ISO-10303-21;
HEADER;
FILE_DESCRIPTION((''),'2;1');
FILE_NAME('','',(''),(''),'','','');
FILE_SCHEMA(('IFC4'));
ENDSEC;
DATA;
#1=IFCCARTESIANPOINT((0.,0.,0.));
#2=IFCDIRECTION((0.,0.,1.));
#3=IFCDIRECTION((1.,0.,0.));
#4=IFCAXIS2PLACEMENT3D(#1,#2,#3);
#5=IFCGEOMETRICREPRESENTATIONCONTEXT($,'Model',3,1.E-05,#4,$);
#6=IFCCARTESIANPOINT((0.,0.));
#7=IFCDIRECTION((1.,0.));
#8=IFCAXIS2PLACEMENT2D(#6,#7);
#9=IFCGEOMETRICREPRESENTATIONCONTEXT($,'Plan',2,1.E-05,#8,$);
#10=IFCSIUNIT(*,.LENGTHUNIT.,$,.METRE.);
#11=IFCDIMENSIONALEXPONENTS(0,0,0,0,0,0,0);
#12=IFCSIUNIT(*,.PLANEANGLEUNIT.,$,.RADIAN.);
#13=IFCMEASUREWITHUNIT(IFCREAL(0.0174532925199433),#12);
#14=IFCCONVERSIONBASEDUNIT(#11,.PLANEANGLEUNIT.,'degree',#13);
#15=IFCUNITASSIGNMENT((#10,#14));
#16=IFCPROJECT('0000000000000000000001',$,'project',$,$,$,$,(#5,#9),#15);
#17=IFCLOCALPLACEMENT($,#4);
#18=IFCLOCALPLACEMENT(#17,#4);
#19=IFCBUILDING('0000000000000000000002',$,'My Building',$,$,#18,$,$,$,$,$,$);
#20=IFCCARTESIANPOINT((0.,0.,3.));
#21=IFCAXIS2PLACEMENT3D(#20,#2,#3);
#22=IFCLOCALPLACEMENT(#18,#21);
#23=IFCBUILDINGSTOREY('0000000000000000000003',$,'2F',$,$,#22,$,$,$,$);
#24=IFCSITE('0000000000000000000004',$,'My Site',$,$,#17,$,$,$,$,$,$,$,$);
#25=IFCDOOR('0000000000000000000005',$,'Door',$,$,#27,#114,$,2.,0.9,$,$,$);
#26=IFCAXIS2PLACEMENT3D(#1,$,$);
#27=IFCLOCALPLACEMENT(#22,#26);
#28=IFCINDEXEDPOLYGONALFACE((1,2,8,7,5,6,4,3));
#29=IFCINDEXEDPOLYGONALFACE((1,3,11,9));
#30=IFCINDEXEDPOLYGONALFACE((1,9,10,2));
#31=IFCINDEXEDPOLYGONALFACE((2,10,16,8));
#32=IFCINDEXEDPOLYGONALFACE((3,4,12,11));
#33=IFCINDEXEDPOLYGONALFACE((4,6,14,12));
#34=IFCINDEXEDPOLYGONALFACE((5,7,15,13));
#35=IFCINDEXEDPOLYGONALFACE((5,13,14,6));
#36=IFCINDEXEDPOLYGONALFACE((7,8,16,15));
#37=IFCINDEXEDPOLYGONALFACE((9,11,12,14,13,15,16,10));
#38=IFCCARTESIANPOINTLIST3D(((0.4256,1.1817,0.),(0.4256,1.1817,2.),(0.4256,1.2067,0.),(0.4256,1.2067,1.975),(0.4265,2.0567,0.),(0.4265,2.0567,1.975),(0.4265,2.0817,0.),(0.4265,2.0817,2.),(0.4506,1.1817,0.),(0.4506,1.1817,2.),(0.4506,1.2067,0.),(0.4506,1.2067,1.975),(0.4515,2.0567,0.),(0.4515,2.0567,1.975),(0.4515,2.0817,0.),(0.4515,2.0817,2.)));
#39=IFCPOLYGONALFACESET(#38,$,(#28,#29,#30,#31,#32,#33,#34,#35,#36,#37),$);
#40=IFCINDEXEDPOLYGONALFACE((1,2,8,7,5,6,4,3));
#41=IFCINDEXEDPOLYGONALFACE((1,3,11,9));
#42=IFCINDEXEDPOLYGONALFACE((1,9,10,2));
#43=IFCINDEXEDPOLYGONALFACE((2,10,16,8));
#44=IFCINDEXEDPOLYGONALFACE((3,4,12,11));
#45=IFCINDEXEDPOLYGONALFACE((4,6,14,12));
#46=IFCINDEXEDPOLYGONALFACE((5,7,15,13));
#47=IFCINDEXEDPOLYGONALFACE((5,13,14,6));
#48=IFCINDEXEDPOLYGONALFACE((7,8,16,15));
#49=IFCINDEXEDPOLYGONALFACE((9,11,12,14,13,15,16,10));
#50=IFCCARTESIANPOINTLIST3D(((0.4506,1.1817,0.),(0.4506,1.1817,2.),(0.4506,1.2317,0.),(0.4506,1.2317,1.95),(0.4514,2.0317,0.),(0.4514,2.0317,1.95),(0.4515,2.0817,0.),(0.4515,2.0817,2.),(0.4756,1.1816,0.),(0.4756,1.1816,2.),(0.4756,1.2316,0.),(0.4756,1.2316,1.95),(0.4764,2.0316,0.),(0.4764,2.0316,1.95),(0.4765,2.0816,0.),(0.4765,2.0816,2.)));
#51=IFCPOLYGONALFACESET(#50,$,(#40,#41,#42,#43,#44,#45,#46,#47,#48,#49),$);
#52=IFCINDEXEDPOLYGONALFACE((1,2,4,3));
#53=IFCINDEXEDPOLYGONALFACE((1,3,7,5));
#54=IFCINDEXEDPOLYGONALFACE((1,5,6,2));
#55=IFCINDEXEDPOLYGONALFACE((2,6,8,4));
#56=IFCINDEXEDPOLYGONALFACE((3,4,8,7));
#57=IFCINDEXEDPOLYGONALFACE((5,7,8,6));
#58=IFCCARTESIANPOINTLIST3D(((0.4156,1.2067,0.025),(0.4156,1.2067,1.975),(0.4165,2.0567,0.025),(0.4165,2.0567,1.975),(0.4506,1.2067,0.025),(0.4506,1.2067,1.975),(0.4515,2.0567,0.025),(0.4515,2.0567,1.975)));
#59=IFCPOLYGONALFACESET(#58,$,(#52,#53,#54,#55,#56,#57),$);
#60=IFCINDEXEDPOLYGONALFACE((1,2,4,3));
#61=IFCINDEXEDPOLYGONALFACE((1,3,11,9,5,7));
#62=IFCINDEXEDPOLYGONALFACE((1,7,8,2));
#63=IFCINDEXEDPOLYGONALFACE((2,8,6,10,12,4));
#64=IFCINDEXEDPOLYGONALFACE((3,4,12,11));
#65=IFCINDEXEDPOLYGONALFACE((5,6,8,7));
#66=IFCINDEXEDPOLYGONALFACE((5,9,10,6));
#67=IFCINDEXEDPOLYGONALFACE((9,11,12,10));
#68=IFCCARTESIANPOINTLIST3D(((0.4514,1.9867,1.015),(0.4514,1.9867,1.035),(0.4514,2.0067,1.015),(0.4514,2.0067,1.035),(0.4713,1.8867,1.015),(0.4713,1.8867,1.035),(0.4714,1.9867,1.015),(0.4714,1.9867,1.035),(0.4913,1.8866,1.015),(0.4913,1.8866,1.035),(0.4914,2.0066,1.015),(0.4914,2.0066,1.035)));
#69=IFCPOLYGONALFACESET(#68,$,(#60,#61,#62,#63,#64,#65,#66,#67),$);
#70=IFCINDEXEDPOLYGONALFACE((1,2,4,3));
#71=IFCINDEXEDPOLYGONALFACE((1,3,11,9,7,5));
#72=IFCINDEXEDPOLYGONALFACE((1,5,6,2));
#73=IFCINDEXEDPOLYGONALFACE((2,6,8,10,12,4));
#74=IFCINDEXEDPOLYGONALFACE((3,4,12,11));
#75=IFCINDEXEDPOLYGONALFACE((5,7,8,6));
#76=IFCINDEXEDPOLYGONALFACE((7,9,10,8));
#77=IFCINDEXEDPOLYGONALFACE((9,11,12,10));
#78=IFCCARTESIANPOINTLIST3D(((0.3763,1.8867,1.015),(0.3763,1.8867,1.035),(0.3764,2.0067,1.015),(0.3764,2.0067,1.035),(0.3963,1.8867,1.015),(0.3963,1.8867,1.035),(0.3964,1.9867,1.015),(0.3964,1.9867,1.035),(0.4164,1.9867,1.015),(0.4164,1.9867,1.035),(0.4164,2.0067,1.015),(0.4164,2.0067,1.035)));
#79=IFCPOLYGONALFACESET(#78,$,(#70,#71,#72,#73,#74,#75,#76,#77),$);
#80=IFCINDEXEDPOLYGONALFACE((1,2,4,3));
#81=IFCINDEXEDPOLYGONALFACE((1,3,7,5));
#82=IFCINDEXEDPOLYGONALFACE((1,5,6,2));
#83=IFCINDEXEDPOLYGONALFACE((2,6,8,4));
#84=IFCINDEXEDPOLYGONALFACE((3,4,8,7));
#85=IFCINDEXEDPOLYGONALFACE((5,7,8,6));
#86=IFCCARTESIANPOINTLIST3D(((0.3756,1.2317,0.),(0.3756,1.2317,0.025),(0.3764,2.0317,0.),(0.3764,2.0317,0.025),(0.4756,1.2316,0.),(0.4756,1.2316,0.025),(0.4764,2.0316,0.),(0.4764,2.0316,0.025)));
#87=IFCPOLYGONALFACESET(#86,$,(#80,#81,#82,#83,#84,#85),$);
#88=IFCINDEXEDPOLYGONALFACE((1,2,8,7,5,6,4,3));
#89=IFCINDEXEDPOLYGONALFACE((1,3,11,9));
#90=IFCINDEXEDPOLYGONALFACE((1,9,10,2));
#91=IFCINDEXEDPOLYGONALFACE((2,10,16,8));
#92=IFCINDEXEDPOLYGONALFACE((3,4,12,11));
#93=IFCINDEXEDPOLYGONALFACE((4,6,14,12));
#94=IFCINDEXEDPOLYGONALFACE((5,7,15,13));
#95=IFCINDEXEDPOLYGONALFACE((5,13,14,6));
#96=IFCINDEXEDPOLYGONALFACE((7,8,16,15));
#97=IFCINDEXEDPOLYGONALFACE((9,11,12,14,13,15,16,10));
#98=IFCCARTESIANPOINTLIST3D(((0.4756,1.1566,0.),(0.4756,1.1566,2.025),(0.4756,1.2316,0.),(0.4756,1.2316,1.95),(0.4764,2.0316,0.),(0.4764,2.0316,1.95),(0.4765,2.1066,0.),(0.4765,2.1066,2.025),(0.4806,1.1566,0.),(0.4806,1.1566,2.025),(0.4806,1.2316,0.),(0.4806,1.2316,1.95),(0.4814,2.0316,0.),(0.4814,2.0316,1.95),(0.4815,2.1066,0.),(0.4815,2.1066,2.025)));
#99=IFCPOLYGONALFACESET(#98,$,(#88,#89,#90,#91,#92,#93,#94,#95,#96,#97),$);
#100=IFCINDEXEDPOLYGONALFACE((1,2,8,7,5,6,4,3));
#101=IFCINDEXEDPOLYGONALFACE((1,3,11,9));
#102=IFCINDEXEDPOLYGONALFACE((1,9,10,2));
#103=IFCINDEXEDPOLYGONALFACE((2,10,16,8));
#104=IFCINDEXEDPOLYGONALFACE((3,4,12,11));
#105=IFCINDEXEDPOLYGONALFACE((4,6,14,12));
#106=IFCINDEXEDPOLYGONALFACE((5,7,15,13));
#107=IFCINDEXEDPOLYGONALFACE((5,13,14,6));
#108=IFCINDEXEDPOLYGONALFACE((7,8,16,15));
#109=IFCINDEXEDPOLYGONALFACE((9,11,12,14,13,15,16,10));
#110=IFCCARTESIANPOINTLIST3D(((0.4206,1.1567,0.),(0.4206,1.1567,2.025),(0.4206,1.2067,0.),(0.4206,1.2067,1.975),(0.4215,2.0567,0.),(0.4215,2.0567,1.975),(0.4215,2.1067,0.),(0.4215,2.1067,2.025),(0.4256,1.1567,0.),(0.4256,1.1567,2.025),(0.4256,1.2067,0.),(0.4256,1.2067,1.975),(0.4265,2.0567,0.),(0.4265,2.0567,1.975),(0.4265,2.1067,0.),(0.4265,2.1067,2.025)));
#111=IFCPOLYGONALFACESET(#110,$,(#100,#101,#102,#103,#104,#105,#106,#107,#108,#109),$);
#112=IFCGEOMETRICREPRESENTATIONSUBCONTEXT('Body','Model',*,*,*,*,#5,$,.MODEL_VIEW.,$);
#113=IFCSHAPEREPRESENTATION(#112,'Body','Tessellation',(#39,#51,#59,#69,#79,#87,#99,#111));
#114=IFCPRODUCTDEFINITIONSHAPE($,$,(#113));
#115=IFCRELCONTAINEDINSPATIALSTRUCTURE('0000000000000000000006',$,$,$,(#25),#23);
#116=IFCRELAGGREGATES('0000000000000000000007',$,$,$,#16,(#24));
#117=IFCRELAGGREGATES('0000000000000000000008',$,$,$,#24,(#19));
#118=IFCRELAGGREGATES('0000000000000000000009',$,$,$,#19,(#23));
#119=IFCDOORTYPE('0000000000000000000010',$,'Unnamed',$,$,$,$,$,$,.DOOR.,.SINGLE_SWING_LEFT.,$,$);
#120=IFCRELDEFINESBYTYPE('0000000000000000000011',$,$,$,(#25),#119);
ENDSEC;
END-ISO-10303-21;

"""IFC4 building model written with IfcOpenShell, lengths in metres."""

from ifc_helpers import new_model, entity, si_unit, converted_unit, frame, origin_with_axes, origin_2d_with_axis, place, context, subcontext, project, spatial, line, indexed_curve, outline, extrude, shape, source, transform, mapped, type_object, type_shapes, element, save


model = new_model("IFC4")

# Units and contexts
model_context = context("Model", 3, precision=1e-05, world=origin_with_axes())
plan_context = context("Plan", 2, precision=1e-05, world=origin_2d_with_axis())
body_context_1 = subcontext(model_context, "Body", "Model", "MODEL_VIEW")
body_context_2 = subcontext(plan_context, "Body", "Plan", "PLAN_VIEW")
ifc_project = project(units=[si_unit("LENGTHUNIT", "METRE"), converted_unit("PLANEANGLEUNIT", "degree", entity("IfcReal", 0.0174532925199433), si_unit("PLANEANGLEUNIT", "RADIAN"), dimensions=[0, 0, 0, 0, 0, 0, 0])], contexts=[model_context, plan_context])

# Site, building, storey
site_placement = place(None, origin_with_axes())
site = spatial("IfcSite", under=ifc_project, at=site_placement, Name="My Site")
building_placement = place(site_placement, origin_with_axes())
building = spatial("IfcBuilding", under=site, at=building_placement, Name="My Building")
storey_placement = place(building_placement, frame((0.0, 0.0, 3.0), z_axis=(0.0, 0.0, 1.0), x_axis=(1.0, 0.0, 0.0)))
storey = spatial("IfcBuildingStorey", under=building, at=storey_placement, Name="2F")

# Shared definitions
door_type = type_object("IfcDoorType", Name="Unnamed", OperationType="SINGLE_SWING_LEFT", PredefinedType="DOOR")
shared_shape_1 = source(origin_with_axes(), body_context_1, "Body", "SweptSolid", [
    extrude(outline(indexed_curve([(0.0, 0.0), (0.0, 2.0), (0.9, 2.0), (0.9, 0.0), (0.875, 0.0), (0.875, 1.975), (0.025, 1.975), (0.025, 0.0)], segments=[line(1, 2, 3, 4, 5, 6, 7, 8, 1)])), frame((0.0, 0.025, 0.0), z_axis=(0.0, -1.0, 0.0), x_axis=(1.0, 0.0, 0.0)), (0.0, 0.0, -1.0), 0.025),
    extrude(outline(indexed_curve([(0.0, 0.0), (0.0, 2.0), (0.9, 2.0), (0.9, 0.0), (0.85, 0.0), (0.85, 1.95), (0.05, 1.95), (0.05, 0.0)], segments=[line(1, 2, 3, 4, 5, 6, 7, 8, 1)])), frame((0.0, 0.0, 0.0), z_axis=(0.0, -1.0, 0.0), x_axis=(1.0, 0.0, 0.0)), (0.0, 0.0, -1.0), 0.025),
    extrude(outline(indexed_curve([(0.0, 0.0), (0.85, 0.0), (0.85, 0.035), (0.0, 0.035)], segments=[line(1, 2, 3, 4, 1)])), frame((0.025, 0.025, 0.025), z_axis=(0.0, 0.0, 1.0), x_axis=(1.0, 0.0, 0.0)), (0.0, 0.0, 1.0), 1.95),
    extrude(outline(indexed_curve([(0.0, 0.0), (0.0, -0.04), (-0.12, -0.04), (-0.12, -0.02), (-0.02, -0.02), (-0.02, 0.0)], segments=[line(1, 2, 3, 4, 5, 6, 1)])), frame((0.825, 0.025, 1.015), z_axis=(0.0, 0.0, 1.0), x_axis=(1.0, 0.0, 0.0)), (0.0, 0.0, 1.0), 0.02),
    extrude(outline(indexed_curve([(0.0, 0.0), (0.0, 0.04), (-0.12, 0.04), (-0.12, 0.02), (-0.02, 0.02), (-0.02, 0.0)], segments=[line(1, 2, 3, 4, 5, 6, 1)])), frame((0.825, 0.06, 1.015), z_axis=(0.0, 0.0, 1.0), x_axis=(1.0, 0.0, 0.0)), (0.0, 0.0, 1.0), 0.02),
    extrude(outline(indexed_curve([(0.0, 0.0), (0.8, 0.0), (0.8, 0.1), (0.0, 0.1)], segments=[line(1, 2, 3, 4, 1)])), frame((0.05, 0.0, 0.0), z_axis=(0.0, 0.0, 1.0), x_axis=(1.0, 0.0, 0.0)), (0.0, 0.0, 1.0), 0.025),
    extrude(outline(indexed_curve([(0.0, 0.0), (0.0, 2.025), (0.95, 2.025), (0.95, 0.0), (0.875, 0.0), (0.875, 1.95), (0.075, 1.95), (0.075, 0.0)], segments=[line(1, 2, 3, 4, 5, 6, 7, 8, 1)])), frame((-0.025, -0.005, 0.0), z_axis=(0.0, -1.0, 0.0), x_axis=(1.0, 0.0, 0.0)), (0.0, 0.0, -1.0), 0.005),
    extrude(outline(indexed_curve([(0.0, 0.0), (0.0, 2.025), (0.95, 2.025), (0.95, 0.0), (0.9, 0.0), (0.9, 1.975), (0.05, 1.975), (0.05, 0.0)], segments=[line(1, 2, 3, 4, 5, 6, 7, 8, 1)])), frame((-0.025, 0.05, 0.0), z_axis=(0.0, -1.0, 0.0), x_axis=(1.0, 0.0, 0.0)), (0.0, 0.0, -1.0), 0.005),
])
shared_shape_2 = source(origin_with_axes(), body_context_2, "Body", "Curve2D", [
    entity("IfcIndexedPolyCurve", entity("IfcCartesianPointList2D", [[0.0, 0.0], [0.0, 0.05], [0.025, 0.05], [0.025, 0.025], [0.05, 0.025], [0.05, 0.0]]), [entity("IfcLineIndex", [1, 2, 3, 4, 5, 6, 1])]),
    entity("IfcIndexedPolyCurve", entity("IfcCartesianPointList2D", [[0.9, 0.0], [0.9, 0.05], [0.875, 0.05], [0.875, 0.025], [0.85, 0.025], [0.85, 0.0]]), [entity("IfcLineIndex", [1, 2, 3, 4, 5, 6, 1])]),
    entity("IfcTrimmedCurve", entity("IfcEllipse", entity("IfcAxis2Placement2D", entity("IfcCartesianPoint", [0.06, 0.05]), entity("IfcDirection", [1.0, 0.0])), 0.815, 0.85), [entity("IfcCartesianPoint", [0.875, 0.05])], [entity("IfcCartesianPoint", [0.06, 0.9])], True, "CARTESIAN"),
    entity("IfcIndexedPolyCurve", entity("IfcCartesianPointList2D", [[0.025, 0.05], [0.06, 0.05], [0.06, 0.9], [0.025, 0.9]]), [entity("IfcLineIndex", [1, 2, 3, 4, 1])]),
])
type_shapes(door_type, [shared_shape_1, shared_shape_2])

# Door
door_1_placement = place(storey_placement, frame((0.4756, 1.1816, 0.0), z_axis=(0.0, 0.0, 1.0), x_axis=(0.000992, 1.0, 0.0)))
element("IfcDoor", 1, at=door_1_placement, inside=storey, type_object=door_type, Name="Door", OverallHeight=2.0, OverallWidth=0.9, shapes=[
    shape(body_context_1, "Body", "MappedRepresentation", [mapped(shared_shape_1, transform((0.0, 0.0, 0.0), x_axis=(1.0, 0.0, 0.0), y_axis=(0.0, 1.0, 0.0), z_axis=(0.0, 0.0, 1.0), scale=1.0))]),
    shape(body_context_2, "Body", "MappedRepresentation", [mapped(shared_shape_2, transform((0.0, 0.0, 0.0), x_axis=(1.0, 0.0, 0.0), y_axis=(0.0, 1.0, 0.0), z_axis=(0.0, 0.0, 1.0), scale=1.0))]),
])

save(model, "model.ifc")
